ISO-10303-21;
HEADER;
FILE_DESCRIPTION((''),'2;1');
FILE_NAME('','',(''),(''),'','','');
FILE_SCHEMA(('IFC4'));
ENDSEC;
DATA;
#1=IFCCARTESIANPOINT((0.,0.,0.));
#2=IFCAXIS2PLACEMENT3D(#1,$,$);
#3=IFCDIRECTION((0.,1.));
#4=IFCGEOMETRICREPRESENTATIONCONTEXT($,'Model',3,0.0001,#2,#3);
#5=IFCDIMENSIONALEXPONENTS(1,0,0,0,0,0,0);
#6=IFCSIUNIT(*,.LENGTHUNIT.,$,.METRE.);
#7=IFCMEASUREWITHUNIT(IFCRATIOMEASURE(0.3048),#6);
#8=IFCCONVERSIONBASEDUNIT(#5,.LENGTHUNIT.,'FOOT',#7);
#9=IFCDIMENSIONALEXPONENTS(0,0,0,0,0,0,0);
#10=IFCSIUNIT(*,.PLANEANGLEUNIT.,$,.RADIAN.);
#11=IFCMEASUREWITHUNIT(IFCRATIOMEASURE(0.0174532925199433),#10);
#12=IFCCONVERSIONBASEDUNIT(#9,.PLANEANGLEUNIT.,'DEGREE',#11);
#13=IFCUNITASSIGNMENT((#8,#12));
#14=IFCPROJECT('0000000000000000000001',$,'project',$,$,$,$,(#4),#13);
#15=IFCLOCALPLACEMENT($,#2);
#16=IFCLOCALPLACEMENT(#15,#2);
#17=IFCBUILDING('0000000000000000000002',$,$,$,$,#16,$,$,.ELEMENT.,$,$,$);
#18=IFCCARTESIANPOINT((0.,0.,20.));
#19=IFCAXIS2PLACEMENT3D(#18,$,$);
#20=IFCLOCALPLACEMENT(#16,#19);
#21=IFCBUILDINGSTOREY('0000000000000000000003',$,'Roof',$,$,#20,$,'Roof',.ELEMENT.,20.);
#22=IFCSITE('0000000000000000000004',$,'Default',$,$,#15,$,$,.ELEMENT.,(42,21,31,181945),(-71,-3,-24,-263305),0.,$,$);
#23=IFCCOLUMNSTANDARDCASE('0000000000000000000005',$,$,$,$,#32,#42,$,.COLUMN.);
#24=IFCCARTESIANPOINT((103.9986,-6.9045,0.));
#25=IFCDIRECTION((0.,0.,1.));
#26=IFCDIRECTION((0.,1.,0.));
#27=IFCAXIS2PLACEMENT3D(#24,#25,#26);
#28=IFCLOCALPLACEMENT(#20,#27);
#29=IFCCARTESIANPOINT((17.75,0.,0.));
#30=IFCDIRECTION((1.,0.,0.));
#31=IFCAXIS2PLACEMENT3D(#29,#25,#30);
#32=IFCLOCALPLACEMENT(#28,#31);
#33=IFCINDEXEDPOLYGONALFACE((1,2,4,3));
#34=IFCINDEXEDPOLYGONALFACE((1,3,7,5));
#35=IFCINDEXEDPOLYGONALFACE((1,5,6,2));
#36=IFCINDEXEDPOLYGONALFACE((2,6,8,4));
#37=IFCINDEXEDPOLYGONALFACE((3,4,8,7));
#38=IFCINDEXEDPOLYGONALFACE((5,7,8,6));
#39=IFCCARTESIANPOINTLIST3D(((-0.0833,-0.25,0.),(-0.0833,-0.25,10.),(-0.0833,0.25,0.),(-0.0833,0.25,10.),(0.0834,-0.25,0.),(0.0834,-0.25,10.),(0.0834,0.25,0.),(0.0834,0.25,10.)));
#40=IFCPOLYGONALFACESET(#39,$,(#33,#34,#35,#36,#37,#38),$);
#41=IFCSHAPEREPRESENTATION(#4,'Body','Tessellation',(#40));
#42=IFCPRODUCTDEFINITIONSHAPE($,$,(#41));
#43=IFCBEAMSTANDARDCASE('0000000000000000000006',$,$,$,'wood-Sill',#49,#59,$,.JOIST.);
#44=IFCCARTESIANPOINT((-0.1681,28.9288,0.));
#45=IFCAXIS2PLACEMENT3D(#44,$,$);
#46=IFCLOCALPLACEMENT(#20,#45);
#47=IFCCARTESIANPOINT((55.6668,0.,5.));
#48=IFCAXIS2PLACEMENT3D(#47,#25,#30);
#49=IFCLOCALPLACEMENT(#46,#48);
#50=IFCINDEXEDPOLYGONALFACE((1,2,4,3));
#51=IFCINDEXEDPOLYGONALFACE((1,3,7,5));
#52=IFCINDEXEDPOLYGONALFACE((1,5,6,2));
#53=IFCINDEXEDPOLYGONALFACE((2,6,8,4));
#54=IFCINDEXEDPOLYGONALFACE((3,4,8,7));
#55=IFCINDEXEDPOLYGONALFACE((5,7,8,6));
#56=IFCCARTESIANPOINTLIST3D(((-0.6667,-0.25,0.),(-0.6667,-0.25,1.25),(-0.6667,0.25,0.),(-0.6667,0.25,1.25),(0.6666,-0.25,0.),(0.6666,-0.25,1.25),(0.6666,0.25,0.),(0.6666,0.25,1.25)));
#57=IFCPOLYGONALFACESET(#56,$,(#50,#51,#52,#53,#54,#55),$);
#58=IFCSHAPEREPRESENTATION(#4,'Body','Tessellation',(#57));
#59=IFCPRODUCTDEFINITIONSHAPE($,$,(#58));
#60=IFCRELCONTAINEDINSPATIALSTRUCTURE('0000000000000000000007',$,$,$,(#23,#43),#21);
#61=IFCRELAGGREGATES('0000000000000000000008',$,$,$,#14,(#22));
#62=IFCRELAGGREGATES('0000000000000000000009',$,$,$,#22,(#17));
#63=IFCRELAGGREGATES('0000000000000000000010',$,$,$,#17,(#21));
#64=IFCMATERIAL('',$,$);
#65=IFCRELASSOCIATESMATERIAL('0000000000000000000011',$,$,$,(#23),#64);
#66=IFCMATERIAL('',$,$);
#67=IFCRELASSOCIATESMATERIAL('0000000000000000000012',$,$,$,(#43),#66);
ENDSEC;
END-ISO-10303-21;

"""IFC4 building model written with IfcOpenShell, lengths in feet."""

from ifc_helpers import new_model, entity, si_unit, converted_unit, direction, frame, origin, place, context, project, spatial, rectangle, extrude, material, element, save


model = new_model("IFC4")

# Units and contexts
model_context = context("Model", 3, precision=0.0001, world=origin(), true_north=direction((0.0, 1.0)))
ifc_project = project(units=[converted_unit("LENGTHUNIT", "FOOT", entity("IfcRatioMeasure", 0.3048), si_unit("LENGTHUNIT", "METRE"), dimensions=[1, 0, 0, 0, 0, 0, 0]), converted_unit("PLANEANGLEUNIT", "DEGREE", entity("IfcRatioMeasure", 0.0174532925199433), si_unit("PLANEANGLEUNIT", "RADIAN"), dimensions=[0, 0, 0, 0, 0, 0, 0])], contexts=[model_context])

# Site, building, storey
site_placement = place(None, origin())
site = spatial("IfcSite", under=ifc_project, at=site_placement, Name="Default", CompositionType="ELEMENT", RefLatitude=(42, 21, 31, 181945), RefLongitude=(-71, -3, -24, -263305), RefElevation=0.0)
building_placement = place(site_placement, origin())
building = spatial("IfcBuilding", under=site, at=building_placement, CompositionType="ELEMENT")
storey_placement = place(building_placement, frame((0.0, 0.0, 20.0)))
storey = spatial("IfcBuildingStorey", under=building, at=storey_placement, Name="Roof", LongName="Roof", CompositionType="ELEMENT", Elevation=20.0)

# Column
placement_1 = place(storey_placement, frame((-0.1681, 28.9288, 0.0)))
ifc_material_1 = material(Name="")
placement_2 = place(storey_placement, frame((103.9986, -6.9045, 0.0), z_axis=(0.0, 0.0, 1.0), x_axis=(0.0, 1.0, 0.0)))
for number, where, z_axis, x_axis in (
    (1, (17.75, 0.0, 0.0), (0.0, 0.0, 1.0), (1.0, 0.0, 0.0)),
):
    element("IfcColumnStandardCase", number, at=place(placement_2, frame(where, z_axis=z_axis, x_axis=x_axis)), inside=storey, material=ifc_material_1, PredefinedType="COLUMN", context=model_context, shape_type="SweptSolid", body=[
        extrude(rectangle(XDim=0.1667, YDim=0.5), origin(), (0.0, 0.0, 1.0), 10.0),
    ])

# Beam
ifc_material_2 = material(Name="")
for number, where, z_axis, x_axis in (
    (2, (55.6668, 0.0, 5.0), (0.0, 0.0, 1.0), (1.0, 0.0, 0.0)),
):
    element("IfcBeamStandardCase", number, at=place(placement_1, frame(where, z_axis=z_axis, x_axis=x_axis)), inside=storey, material=ifc_material_2, ObjectType="wood-Sill", PredefinedType="JOIST", context=model_context, shape_type="SweptSolid", body=[
        extrude(rectangle(XDim=1.3333, YDim=0.5), origin(), (0.0, 0.0, 1.0), 1.25),
    ])

save(model, "model.ifc")
